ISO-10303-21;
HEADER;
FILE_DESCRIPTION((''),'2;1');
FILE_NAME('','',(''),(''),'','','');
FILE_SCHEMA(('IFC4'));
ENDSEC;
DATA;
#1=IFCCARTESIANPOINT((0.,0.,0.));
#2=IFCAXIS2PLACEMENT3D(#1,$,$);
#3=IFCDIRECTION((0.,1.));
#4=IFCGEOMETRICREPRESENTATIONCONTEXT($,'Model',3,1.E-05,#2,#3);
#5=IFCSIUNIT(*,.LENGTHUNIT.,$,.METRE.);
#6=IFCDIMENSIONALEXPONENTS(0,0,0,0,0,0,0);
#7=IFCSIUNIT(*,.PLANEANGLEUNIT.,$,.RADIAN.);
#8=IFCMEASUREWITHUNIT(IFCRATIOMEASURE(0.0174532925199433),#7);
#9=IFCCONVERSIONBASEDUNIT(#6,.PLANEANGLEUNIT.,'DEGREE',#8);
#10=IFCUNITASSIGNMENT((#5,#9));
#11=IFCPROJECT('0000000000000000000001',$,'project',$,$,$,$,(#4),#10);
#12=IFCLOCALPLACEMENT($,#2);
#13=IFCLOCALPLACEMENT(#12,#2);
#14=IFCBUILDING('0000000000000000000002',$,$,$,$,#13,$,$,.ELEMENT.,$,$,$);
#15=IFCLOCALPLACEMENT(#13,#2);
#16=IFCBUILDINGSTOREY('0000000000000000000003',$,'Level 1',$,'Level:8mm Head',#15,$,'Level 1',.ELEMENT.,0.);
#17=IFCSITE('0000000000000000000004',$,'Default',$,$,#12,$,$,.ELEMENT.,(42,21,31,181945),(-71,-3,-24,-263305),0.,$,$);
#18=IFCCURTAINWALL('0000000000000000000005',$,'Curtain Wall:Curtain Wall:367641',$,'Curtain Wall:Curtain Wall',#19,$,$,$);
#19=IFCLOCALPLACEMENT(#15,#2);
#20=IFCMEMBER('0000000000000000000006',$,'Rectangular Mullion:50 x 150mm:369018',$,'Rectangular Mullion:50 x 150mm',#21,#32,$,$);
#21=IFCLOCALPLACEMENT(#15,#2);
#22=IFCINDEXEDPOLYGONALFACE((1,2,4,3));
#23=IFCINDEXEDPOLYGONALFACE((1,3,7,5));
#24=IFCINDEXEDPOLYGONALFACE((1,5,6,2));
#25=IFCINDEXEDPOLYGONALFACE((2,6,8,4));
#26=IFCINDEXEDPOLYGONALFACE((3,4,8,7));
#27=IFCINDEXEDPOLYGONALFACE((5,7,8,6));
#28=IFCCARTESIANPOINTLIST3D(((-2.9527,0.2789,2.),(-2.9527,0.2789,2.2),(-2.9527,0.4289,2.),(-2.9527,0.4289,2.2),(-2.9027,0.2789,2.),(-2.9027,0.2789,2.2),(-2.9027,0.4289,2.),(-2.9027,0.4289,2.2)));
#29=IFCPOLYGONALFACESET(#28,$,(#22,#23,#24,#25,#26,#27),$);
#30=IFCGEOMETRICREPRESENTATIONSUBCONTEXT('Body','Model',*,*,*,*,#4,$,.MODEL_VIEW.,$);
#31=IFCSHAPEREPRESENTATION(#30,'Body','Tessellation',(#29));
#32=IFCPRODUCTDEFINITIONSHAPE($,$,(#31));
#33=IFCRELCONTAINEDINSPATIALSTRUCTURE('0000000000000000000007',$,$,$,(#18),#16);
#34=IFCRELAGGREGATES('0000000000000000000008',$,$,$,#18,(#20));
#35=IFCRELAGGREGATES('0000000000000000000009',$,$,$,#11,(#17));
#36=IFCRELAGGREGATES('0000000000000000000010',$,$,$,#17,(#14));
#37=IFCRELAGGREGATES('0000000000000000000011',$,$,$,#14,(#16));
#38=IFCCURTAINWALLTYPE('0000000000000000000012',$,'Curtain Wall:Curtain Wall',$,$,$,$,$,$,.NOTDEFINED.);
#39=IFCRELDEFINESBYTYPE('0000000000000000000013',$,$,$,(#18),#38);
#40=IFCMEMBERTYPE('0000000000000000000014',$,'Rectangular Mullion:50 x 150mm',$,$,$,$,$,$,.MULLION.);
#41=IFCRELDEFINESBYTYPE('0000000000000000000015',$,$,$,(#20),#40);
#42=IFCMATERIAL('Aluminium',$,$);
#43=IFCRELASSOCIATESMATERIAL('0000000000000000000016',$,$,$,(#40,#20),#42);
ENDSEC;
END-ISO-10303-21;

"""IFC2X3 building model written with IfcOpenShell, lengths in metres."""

from ifc_helpers import new_model, entity, si_unit, converted_unit, direction, frame, origin, origin_2d_with_axis, place, context, subcontext, project, spatial, rectangle, extrude, source, transform, mapped, material, type_object, type_shapes, element, aggregate, save


model = new_model("IFC2X3")

# Units and contexts
model_context = context("Model", 3, precision=1e-05, world=origin(), true_north=direction((0.0, 1.0)))
body_context = subcontext(model_context, "Body", "Model", "MODEL_VIEW")
ifc_project = project(units=[si_unit("LENGTHUNIT", "METRE"), converted_unit("PLANEANGLEUNIT", "DEGREE", entity("IfcRatioMeasure", 0.0174532925199433), si_unit("PLANEANGLEUNIT", "RADIAN"), dimensions=[0, 0, 0, 0, 0, 0, 0])], contexts=[model_context])

# Site, building, storey
site_placement = place(None, origin())
site = spatial("IfcSite", under=ifc_project, at=site_placement, Name="Default", CompositionType="ELEMENT", RefLatitude=(42, 21, 31, 181945), RefLongitude=(-71, -3, -24, -263305), RefElevation=0.0)
building_placement = place(site_placement, origin())
building = spatial("IfcBuilding", under=site, at=building_placement, CompositionType="ELEMENT")
storey_placement = place(building_placement, origin())
storey = spatial("IfcBuildingStorey", under=building, at=storey_placement, Name="Level 1", ObjectType="Level:8mm Head", LongName="Level 1", CompositionType="ELEMENT", Elevation=0.0)

# Curtain wall, member
curtain_wall_type = type_object("IfcCurtainWallType", Name="Curtain Wall:Curtain Wall", PredefinedType="NOTDEFINED")
curtain_wall_placement = place(storey_placement, origin())
curtain_wall = element("IfcCurtainWall", 1, at=curtain_wall_placement, inside=storey, type_object=curtain_wall_type, Name="Curtain Wall:Curtain Wall:367641", ObjectType="Curtain Wall:Curtain Wall")
ifc_material_1 = material(Name="Aluminium")
member_type_1 = type_object("IfcMemberType", Name="Rectangular Mullion:50 x 150mm", PredefinedType="MULLION", material=ifc_material_1)
shared_shape_1 = source(origin(), body_context, "Body", "SweptSolid", [
    extrude(rectangle(XDim=0.15, YDim=0.05, at=origin_2d_with_axis()), frame((0.0, 0.0, -0.2), z_axis=(0.0, 0.0, 1.0), x_axis=(0.0, -1.0, 0.0)), (0.0, 0.0, 1.0), 0.2),
])
type_shapes(member_type_1, [shared_shape_1])
member_1_placement = place(storey_placement, frame((-2.9277, 0.3539, 2.0), z_axis=(0.0, 0.0, -1.0), x_axis=(1.0, 0.0, 0.0)))
member_1 = element("IfcMember", 2, at=member_1_placement, type_object=member_type_1, material=ifc_material_1, Name="Rectangular Mullion:50 x 150mm:369018", ObjectType="Rectangular Mullion:50 x 150mm", context=body_context, shape_type="MappedRepresentation", body=[
    mapped(shared_shape_1, transform((0.0, 0.0, 0.0), scale=1.0)),
])
aggregate(curtain_wall, [member_1])

save(model, "model.ifc")
